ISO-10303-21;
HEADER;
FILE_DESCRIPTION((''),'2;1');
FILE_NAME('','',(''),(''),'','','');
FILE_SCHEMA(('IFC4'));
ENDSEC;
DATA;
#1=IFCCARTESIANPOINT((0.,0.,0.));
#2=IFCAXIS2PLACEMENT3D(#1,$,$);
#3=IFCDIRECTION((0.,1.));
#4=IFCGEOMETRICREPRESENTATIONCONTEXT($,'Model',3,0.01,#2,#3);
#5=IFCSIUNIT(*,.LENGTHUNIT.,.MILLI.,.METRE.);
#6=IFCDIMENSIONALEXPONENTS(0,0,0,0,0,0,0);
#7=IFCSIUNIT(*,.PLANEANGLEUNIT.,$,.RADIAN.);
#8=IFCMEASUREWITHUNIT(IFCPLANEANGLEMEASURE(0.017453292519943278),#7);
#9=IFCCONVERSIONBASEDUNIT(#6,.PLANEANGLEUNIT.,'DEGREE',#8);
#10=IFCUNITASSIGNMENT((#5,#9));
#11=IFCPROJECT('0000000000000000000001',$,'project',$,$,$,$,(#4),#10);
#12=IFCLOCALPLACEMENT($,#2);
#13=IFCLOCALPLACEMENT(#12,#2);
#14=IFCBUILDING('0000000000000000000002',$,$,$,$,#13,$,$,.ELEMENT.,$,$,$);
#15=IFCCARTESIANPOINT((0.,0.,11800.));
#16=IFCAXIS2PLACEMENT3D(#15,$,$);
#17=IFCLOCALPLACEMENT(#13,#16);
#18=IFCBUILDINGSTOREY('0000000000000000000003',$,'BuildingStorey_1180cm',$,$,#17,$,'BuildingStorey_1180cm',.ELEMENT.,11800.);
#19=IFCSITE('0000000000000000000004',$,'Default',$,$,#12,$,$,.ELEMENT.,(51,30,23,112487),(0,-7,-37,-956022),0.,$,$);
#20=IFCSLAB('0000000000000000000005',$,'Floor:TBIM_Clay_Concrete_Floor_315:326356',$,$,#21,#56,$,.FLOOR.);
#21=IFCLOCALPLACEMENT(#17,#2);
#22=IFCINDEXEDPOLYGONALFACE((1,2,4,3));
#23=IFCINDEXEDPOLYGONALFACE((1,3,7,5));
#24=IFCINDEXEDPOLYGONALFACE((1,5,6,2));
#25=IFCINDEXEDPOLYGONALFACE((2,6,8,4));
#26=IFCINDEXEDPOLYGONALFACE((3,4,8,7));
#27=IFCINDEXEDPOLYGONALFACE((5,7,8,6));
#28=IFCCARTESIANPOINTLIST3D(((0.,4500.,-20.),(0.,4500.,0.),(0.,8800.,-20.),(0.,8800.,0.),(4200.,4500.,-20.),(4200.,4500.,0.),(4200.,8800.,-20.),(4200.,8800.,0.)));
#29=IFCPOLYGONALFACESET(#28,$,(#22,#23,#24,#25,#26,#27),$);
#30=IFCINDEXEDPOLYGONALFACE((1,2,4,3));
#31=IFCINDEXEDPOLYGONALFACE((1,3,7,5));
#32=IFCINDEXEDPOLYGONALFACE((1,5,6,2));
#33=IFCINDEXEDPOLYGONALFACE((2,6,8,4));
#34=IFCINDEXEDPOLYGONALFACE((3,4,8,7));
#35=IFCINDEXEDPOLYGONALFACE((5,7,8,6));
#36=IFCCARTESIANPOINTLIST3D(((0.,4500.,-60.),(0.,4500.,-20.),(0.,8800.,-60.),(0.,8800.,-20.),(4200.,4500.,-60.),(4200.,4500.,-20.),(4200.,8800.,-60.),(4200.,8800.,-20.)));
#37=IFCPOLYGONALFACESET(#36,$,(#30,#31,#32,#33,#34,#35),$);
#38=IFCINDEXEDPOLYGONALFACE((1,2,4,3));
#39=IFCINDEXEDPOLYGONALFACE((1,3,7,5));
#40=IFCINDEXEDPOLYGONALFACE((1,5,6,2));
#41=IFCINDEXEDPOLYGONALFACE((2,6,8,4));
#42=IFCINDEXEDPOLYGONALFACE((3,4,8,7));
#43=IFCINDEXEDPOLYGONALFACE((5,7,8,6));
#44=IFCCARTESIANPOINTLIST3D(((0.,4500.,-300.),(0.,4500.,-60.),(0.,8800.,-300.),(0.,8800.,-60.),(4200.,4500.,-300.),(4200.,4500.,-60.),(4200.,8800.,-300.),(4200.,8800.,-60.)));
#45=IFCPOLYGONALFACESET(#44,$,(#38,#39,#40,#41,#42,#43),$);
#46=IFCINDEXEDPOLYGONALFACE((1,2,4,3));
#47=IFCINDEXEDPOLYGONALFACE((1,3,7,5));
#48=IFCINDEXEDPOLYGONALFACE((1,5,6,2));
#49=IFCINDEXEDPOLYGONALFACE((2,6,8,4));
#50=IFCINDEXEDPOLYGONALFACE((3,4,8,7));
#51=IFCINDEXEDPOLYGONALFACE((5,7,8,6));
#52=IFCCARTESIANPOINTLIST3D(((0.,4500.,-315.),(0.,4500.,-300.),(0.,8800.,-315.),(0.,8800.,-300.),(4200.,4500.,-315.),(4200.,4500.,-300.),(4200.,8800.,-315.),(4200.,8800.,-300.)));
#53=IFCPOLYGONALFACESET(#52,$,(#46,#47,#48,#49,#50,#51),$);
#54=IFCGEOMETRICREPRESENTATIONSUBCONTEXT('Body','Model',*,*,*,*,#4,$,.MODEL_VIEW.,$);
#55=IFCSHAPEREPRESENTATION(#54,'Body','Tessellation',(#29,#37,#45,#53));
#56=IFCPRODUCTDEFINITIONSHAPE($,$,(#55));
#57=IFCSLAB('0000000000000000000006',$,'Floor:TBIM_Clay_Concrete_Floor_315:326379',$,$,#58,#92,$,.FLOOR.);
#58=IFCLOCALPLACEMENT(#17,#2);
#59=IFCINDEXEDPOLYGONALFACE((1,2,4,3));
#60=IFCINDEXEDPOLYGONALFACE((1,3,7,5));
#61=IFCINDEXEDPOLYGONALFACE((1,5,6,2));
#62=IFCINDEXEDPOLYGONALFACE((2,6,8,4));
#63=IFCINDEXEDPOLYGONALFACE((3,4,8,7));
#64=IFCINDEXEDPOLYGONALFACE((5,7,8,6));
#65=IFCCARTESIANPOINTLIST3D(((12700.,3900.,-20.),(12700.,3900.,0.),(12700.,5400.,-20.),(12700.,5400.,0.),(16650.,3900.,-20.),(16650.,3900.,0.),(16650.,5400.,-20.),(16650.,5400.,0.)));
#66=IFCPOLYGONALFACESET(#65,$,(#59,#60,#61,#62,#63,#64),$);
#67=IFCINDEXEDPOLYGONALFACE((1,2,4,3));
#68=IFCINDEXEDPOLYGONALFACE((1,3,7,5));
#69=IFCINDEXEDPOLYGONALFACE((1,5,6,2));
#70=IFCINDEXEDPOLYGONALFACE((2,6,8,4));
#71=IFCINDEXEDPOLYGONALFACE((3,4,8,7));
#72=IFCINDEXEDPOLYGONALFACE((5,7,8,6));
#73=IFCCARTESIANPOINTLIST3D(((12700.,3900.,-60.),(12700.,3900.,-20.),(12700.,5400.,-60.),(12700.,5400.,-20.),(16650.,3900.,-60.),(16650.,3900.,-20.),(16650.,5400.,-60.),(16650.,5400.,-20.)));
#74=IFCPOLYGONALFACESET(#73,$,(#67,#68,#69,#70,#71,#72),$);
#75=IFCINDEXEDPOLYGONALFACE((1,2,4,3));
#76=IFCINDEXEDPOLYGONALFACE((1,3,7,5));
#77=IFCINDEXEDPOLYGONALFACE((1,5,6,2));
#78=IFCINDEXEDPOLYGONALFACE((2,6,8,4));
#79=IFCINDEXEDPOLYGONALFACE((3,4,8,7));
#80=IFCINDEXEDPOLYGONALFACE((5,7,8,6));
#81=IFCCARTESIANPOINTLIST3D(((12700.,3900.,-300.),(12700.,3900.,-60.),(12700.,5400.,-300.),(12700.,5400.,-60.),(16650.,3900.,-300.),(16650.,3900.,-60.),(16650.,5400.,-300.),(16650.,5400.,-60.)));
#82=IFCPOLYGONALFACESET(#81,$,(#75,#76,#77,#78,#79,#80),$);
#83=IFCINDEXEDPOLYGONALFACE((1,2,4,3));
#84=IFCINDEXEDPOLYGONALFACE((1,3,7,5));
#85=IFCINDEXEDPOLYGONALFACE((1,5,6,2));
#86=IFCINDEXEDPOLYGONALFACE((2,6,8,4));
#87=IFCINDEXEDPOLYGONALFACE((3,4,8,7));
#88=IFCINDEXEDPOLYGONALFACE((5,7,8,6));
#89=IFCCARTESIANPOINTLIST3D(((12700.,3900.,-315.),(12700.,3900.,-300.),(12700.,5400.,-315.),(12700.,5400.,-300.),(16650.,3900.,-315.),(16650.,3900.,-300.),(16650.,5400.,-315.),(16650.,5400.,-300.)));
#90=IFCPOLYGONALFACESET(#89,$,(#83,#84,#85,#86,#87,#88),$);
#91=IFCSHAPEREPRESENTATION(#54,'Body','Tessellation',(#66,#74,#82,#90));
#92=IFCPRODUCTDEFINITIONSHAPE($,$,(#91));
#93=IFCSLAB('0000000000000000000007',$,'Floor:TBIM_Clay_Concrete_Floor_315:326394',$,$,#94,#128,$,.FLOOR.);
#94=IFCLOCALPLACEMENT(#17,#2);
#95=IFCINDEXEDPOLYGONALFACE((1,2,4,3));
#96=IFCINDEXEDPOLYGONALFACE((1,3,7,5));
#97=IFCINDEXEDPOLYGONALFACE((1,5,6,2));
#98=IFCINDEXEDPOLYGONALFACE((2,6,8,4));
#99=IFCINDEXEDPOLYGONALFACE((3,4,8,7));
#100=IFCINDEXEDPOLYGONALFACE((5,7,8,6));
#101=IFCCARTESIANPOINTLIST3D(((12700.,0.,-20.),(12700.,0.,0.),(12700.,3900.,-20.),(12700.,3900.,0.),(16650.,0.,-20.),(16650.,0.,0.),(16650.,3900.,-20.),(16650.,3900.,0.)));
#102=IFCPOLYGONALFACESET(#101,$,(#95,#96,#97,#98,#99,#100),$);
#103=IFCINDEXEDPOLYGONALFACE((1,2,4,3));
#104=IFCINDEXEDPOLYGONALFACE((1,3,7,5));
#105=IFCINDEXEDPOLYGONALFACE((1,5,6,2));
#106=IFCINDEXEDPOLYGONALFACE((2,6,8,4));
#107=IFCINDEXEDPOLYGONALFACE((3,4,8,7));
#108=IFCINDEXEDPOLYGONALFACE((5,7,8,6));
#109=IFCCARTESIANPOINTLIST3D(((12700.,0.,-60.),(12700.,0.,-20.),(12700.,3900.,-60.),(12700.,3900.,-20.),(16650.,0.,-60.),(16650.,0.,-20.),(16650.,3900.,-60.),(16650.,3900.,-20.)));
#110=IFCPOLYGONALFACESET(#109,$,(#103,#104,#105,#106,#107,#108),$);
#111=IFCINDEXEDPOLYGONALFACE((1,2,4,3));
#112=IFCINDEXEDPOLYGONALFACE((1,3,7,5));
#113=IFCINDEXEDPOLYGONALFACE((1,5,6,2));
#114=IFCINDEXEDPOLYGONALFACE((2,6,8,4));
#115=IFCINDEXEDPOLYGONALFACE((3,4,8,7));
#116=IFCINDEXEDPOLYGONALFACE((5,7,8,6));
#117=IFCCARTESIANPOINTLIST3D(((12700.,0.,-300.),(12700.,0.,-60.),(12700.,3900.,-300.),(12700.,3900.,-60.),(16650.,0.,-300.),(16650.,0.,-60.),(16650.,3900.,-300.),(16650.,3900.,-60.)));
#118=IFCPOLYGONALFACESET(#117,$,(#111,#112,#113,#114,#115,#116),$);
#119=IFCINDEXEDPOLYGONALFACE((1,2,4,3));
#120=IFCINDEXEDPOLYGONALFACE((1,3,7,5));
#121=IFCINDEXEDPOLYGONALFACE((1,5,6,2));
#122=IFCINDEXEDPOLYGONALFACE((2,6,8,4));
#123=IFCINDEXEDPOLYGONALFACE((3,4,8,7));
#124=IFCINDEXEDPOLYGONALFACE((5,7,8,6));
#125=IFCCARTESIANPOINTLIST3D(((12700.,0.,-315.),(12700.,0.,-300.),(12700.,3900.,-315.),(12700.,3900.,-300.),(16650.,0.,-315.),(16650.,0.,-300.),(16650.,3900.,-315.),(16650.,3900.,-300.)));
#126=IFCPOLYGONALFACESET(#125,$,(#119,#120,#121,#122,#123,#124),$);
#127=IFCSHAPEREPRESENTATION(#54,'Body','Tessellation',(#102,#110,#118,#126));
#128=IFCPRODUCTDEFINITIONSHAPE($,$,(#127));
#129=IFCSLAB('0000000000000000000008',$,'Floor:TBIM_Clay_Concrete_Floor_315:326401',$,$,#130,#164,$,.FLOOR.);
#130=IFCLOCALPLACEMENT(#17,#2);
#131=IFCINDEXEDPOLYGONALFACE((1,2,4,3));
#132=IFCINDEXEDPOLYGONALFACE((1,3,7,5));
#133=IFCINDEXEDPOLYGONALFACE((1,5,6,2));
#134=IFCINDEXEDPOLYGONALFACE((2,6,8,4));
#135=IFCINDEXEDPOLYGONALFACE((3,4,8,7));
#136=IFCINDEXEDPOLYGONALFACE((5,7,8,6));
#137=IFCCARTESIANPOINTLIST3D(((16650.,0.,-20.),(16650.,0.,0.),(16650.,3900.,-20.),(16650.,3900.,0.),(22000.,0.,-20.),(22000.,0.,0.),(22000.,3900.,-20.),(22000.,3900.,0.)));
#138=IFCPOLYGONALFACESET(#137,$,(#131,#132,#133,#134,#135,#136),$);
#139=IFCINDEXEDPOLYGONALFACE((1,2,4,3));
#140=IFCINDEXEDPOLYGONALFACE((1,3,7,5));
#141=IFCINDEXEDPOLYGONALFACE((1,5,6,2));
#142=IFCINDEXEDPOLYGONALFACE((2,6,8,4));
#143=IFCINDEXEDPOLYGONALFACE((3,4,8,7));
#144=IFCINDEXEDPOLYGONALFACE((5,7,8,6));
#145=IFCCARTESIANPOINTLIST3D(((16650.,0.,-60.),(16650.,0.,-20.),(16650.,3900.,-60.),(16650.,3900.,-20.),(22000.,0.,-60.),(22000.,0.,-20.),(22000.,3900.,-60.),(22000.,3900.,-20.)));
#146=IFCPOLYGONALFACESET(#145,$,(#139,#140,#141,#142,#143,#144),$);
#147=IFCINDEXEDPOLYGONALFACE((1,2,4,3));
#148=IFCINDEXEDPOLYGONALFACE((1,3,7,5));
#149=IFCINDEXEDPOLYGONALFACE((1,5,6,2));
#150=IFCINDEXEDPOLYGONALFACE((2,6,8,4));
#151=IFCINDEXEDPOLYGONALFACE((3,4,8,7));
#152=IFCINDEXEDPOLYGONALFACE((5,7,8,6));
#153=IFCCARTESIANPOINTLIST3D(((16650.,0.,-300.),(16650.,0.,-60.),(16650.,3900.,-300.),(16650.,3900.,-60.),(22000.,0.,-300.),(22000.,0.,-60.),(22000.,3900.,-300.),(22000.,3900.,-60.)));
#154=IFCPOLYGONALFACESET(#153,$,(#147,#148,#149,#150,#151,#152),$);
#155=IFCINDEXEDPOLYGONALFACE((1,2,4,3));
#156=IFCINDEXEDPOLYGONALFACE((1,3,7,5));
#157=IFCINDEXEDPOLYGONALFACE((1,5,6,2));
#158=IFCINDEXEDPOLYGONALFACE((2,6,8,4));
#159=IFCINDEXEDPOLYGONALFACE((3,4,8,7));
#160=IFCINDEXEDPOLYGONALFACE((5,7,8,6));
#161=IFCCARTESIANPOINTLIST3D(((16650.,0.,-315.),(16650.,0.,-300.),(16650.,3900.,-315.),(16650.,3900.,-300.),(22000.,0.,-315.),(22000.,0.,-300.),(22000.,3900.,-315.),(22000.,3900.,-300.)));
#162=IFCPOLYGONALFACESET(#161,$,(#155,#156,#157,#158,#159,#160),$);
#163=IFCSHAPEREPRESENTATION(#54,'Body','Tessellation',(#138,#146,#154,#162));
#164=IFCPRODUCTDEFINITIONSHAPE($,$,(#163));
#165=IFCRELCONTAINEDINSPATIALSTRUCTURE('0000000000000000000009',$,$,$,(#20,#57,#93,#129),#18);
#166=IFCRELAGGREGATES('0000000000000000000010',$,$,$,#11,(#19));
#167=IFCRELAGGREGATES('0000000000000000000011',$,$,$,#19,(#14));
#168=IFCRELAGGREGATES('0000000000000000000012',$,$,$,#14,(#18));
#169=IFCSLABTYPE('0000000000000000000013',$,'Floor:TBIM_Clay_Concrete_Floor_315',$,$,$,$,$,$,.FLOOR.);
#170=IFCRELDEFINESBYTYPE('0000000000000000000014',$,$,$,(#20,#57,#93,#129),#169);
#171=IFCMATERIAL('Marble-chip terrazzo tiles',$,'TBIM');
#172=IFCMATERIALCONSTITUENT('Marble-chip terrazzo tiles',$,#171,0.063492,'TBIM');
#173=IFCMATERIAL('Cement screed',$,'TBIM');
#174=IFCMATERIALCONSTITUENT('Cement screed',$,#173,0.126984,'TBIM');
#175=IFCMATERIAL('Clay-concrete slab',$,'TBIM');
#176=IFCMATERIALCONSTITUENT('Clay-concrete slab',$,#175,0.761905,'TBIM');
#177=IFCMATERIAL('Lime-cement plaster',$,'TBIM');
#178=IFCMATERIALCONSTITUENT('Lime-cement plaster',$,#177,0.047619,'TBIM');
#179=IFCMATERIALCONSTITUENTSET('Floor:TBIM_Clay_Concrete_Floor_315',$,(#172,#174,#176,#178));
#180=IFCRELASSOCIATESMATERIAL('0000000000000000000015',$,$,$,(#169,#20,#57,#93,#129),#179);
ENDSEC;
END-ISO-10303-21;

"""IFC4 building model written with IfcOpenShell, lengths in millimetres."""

from ifc_helpers import new_model, entity, si_unit, converted_unit, direction, frame, origin, place, context, subcontext, project, spatial, indexed_curve, outline, extrude, material, constituent, constituent_set, type_object, element, save


model = new_model("IFC4")

# Units and contexts
model_context = context("Model", 3, precision=0.01, world=origin(), true_north=direction((0.0, 1.0)))
body_context = subcontext(model_context, "Body", "Model", "MODEL_VIEW")
ifc_project = project(units=[si_unit("LENGTHUNIT", "METRE", prefix="MILLI"), converted_unit("PLANEANGLEUNIT", "DEGREE", entity("IfcPlaneAngleMeasure", 0.017453292519943278), si_unit("PLANEANGLEUNIT", "RADIAN"), dimensions=[0, 0, 0, 0, 0, 0, 0])], contexts=[model_context])

# Site, building, storey
site_placement = place(None, origin())
site = spatial("IfcSite", under=ifc_project, at=site_placement, Name="Default", CompositionType="ELEMENT", RefLatitude=(51, 30, 23, 112487), RefLongitude=(0, -7, -37, -956022), RefElevation=0.0)
building_placement = place(site_placement, origin())
building = spatial("IfcBuilding", under=site, at=building_placement, CompositionType="ELEMENT")
storey_placement = place(building_placement, frame((0.0, 0.0, 11800.0)))
storey = spatial("IfcBuildingStorey", under=building, at=storey_placement, Name="BuildingStorey_1180cm", LongName="BuildingStorey_1180cm", CompositionType="ELEMENT", Elevation=11800.0)

# Slabs
ifc_material_1 = material(Name="Marble-chip terrazzo tiles", Category="TBIM")
ifc_constituent_1 = constituent(ifc_material_1, Name="Marble-chip terrazzo tiles", Category="TBIM", fraction=0.063492)
ifc_material_2 = material(Name="Cement screed", Category="TBIM")
ifc_constituent_2 = constituent(ifc_material_2, Name="Cement screed", Category="TBIM", fraction=0.126984)
ifc_material_3 = material(Name="Clay-concrete slab", Category="TBIM")
ifc_constituent_3 = constituent(ifc_material_3, Name="Clay-concrete slab", Category="TBIM", fraction=0.761905)
ifc_material_4 = material(Name="Lime-cement plaster", Category="TBIM")
ifc_constituent_4 = constituent(ifc_material_4, Name="Lime-cement plaster", Category="TBIM", fraction=0.047619)
ifc_constituent_set_1 = constituent_set(constituents=[ifc_constituent_1, ifc_constituent_2, ifc_constituent_3, ifc_constituent_4], Name="Floor:TBIM_Clay_Concrete_Floor_315")
slab_type = type_object("IfcSlabType", Name="Floor:TBIM_Clay_Concrete_Floor_315", PredefinedType="FLOOR", material=ifc_constituent_set_1)
slab_1_placement = place(storey_placement, origin())
element("IfcSlab", 1, at=slab_1_placement, inside=storey, type_object=slab_type, material=ifc_constituent_set_1, Name="Floor:TBIM_Clay_Concrete_Floor_315:326356", PredefinedType="FLOOR", context=body_context, shape_type="SweptSolid", body=[
    extrude(outline(indexed_curve([(-2100.0, -2150.0), (2100.0, -2150.0), (2100.0, 2150.0), (-2100.0, 2150.0), (-2100.0, -2150.0)], self_intersect=False)), frame((2100.0, 6650.0, -20.0), z_axis=(0.0, 0.0, 1.0), x_axis=(-1.0, 0.0, 0.0)), (0.0, 0.0, 1.0), 20.0),
    extrude(outline(indexed_curve([(-2100.0, -2150.0), (2100.0, -2150.0), (2100.0, 2150.0), (-2100.0, 2150.0), (-2100.0, -2150.0)], self_intersect=False)), frame((2100.0, 6650.0, -60.0), z_axis=(0.0, 0.0, 1.0), x_axis=(-1.0, 0.0, 0.0)), (0.0, 0.0, 1.0), 40.0),
    extrude(outline(indexed_curve([(-2100.0, -2150.0), (2100.0, -2150.0), (2100.0, 2150.0), (-2100.0, 2150.0), (-2100.0, -2150.0)], self_intersect=False)), frame((2100.0, 6650.0, -300.0), z_axis=(0.0, 0.0, 1.0), x_axis=(-1.0, 0.0, 0.0)), (0.0, 0.0, 1.0), 240.0),
    extrude(outline(indexed_curve([(-2100.0, -2150.0), (2100.0, -2150.0), (2100.0, 2150.0), (-2100.0, 2150.0), (-2100.0, -2150.0)], self_intersect=False)), frame((2100.0, 6650.0, -315.0), z_axis=(0.0, 0.0, 1.0), x_axis=(-1.0, 0.0, 0.0)), (0.0, 0.0, 1.0), 15.0),
])
slab_2_placement = place(storey_placement, origin())
element("IfcSlab", 2, at=slab_2_placement, inside=storey, type_object=slab_type, material=ifc_constituent_set_1, Name="Floor:TBIM_Clay_Concrete_Floor_315:326379", PredefinedType="FLOOR", context=body_context, shape_type="SweptSolid", body=[
    extrude(outline(indexed_curve([(-750.0, -1975.0), (750.0, -1975.0), (750.0, 1975.0), (-750.0, 1975.0), (-750.0, -1975.0)], self_intersect=False)), frame((14675.0, 4650.0, -20.0), z_axis=(0.0, 0.0, 1.0), x_axis=(0.0, 1.0, 0.0)), (0.0, 0.0, 1.0), 20.0),
    extrude(outline(indexed_curve([(-750.0, -1975.0), (750.0, -1975.0), (750.0, 1975.0), (-750.0, 1975.0), (-750.0, -1975.0)], self_intersect=False)), frame((14675.0, 4650.0, -60.0), z_axis=(0.0, 0.0, 1.0), x_axis=(0.0, 1.0, 0.0)), (0.0, 0.0, 1.0), 40.0),
    extrude(outline(indexed_curve([(-750.0, -1975.0), (750.0, -1975.0), (750.0, 1975.0), (-750.0, 1975.0), (-750.0, -1975.0)], self_intersect=False)), frame((14675.0, 4650.0, -300.0), z_axis=(0.0, 0.0, 1.0), x_axis=(0.0, 1.0, 0.0)), (0.0, 0.0, 1.0), 240.0),
    extrude(outline(indexed_curve([(-750.0, -1975.0), (750.0, -1975.0), (750.0, 1975.0), (-750.0, 1975.0), (-750.0, -1975.0)], self_intersect=False)), frame((14675.0, 4650.0, -315.0), z_axis=(0.0, 0.0, 1.0), x_axis=(0.0, 1.0, 0.0)), (0.0, 0.0, 1.0), 15.0),
])
slab_3_placement = place(storey_placement, origin())
element("IfcSlab", 3, at=slab_3_placement, inside=storey, type_object=slab_type, material=ifc_constituent_set_1, Name="Floor:TBIM_Clay_Concrete_Floor_315:326394", PredefinedType="FLOOR", context=body_context, shape_type="SweptSolid", body=[
    extrude(outline(indexed_curve([(-1975.0, -1950.0), (1975.0, -1950.0), (1975.0, 1950.0), (-1975.0, 1950.0), (-1975.0, -1950.0)], self_intersect=False)), frame((14675.0, 1950.0, -20.0), z_axis=(0.0, 0.0, 1.0), x_axis=(-1.0, 0.0, 0.0)), (0.0, 0.0, 1.0), 20.0),
    extrude(outline(indexed_curve([(-1975.0, -1950.0), (1975.0, -1950.0), (1975.0, 1950.0), (-1975.0, 1950.0), (-1975.0, -1950.0)], self_intersect=False)), frame((14675.0, 1950.0, -60.0), z_axis=(0.0, 0.0, 1.0), x_axis=(-1.0, 0.0, 0.0)), (0.0, 0.0, 1.0), 40.0),
    extrude(outline(indexed_curve([(-1975.0, -1950.0), (1975.0, -1950.0), (1975.0, 1950.0), (-1975.0, 1950.0), (-1975.0, -1950.0)], self_intersect=False)), frame((14675.0, 1950.0, -300.0), z_axis=(0.0, 0.0, 1.0), x_axis=(-1.0, 0.0, 0.0)), (0.0, 0.0, 1.0), 240.0),
    extrude(outline(indexed_curve([(-1975.0, -1950.0), (1975.0, -1950.0), (1975.0, 1950.0), (-1975.0, 1950.0), (-1975.0, -1950.0)], self_intersect=False)), frame((14675.0, 1950.0, -315.0), z_axis=(0.0, 0.0, 1.0), x_axis=(-1.0, 0.0, 0.0)), (0.0, 0.0, 1.0), 15.0),
])
slab_4_placement = place(storey_placement, origin())
element("IfcSlab", 4, at=slab_4_placement, inside=storey, type_object=slab_type, material=ifc_constituent_set_1, Name="Floor:TBIM_Clay_Concrete_Floor_315:326401", PredefinedType="FLOOR", context=body_context, shape_type="SweptSolid", body=[
    extrude(outline(indexed_curve([(-2675.0, -1950.0), (2675.0, -1950.0), (2675.0, 1950.0), (-2675.0, 1950.0), (-2675.0, -1950.0)], self_intersect=False)), frame((19325.0, 1950.0, -20.0), z_axis=(0.0, 0.0, 1.0), x_axis=(-1.0, 0.0, 0.0)), (0.0, 0.0, 1.0), 20.0),
    extrude(outline(indexed_curve([(-2675.0, -1950.0), (2675.0, -1950.0), (2675.0, 1950.0), (-2675.0, 1950.0), (-2675.0, -1950.0)], self_intersect=False)), frame((19325.0, 1950.0, -60.0), z_axis=(0.0, 0.0, 1.0), x_axis=(-1.0, 0.0, 0.0)), (0.0, 0.0, 1.0), 40.0),
    extrude(outline(indexed_curve([(-2675.0, -1950.0), (2675.0, -1950.0), (2675.0, 1950.0), (-2675.0, 1950.0), (-2675.0, -1950.0)], self_intersect=False)), frame((19325.0, 1950.0, -300.0), z_axis=(0.0, 0.0, 1.0), x_axis=(-1.0, 0.0, 0.0)), (0.0, 0.0, 1.0), 240.0),
    extrude(outline(indexed_curve([(-2675.0, -1950.0), (2675.0, -1950.0), (2675.0, 1950.0), (-2675.0, 1950.0), (-2675.0, -1950.0)], self_intersect=False)), frame((19325.0, 1950.0, -315.0), z_axis=(0.0, 0.0, 1.0), x_axis=(-1.0, 0.0, 0.0)), (0.0, 0.0, 1.0), 15.0),
])

save(model, "model.ifc")
